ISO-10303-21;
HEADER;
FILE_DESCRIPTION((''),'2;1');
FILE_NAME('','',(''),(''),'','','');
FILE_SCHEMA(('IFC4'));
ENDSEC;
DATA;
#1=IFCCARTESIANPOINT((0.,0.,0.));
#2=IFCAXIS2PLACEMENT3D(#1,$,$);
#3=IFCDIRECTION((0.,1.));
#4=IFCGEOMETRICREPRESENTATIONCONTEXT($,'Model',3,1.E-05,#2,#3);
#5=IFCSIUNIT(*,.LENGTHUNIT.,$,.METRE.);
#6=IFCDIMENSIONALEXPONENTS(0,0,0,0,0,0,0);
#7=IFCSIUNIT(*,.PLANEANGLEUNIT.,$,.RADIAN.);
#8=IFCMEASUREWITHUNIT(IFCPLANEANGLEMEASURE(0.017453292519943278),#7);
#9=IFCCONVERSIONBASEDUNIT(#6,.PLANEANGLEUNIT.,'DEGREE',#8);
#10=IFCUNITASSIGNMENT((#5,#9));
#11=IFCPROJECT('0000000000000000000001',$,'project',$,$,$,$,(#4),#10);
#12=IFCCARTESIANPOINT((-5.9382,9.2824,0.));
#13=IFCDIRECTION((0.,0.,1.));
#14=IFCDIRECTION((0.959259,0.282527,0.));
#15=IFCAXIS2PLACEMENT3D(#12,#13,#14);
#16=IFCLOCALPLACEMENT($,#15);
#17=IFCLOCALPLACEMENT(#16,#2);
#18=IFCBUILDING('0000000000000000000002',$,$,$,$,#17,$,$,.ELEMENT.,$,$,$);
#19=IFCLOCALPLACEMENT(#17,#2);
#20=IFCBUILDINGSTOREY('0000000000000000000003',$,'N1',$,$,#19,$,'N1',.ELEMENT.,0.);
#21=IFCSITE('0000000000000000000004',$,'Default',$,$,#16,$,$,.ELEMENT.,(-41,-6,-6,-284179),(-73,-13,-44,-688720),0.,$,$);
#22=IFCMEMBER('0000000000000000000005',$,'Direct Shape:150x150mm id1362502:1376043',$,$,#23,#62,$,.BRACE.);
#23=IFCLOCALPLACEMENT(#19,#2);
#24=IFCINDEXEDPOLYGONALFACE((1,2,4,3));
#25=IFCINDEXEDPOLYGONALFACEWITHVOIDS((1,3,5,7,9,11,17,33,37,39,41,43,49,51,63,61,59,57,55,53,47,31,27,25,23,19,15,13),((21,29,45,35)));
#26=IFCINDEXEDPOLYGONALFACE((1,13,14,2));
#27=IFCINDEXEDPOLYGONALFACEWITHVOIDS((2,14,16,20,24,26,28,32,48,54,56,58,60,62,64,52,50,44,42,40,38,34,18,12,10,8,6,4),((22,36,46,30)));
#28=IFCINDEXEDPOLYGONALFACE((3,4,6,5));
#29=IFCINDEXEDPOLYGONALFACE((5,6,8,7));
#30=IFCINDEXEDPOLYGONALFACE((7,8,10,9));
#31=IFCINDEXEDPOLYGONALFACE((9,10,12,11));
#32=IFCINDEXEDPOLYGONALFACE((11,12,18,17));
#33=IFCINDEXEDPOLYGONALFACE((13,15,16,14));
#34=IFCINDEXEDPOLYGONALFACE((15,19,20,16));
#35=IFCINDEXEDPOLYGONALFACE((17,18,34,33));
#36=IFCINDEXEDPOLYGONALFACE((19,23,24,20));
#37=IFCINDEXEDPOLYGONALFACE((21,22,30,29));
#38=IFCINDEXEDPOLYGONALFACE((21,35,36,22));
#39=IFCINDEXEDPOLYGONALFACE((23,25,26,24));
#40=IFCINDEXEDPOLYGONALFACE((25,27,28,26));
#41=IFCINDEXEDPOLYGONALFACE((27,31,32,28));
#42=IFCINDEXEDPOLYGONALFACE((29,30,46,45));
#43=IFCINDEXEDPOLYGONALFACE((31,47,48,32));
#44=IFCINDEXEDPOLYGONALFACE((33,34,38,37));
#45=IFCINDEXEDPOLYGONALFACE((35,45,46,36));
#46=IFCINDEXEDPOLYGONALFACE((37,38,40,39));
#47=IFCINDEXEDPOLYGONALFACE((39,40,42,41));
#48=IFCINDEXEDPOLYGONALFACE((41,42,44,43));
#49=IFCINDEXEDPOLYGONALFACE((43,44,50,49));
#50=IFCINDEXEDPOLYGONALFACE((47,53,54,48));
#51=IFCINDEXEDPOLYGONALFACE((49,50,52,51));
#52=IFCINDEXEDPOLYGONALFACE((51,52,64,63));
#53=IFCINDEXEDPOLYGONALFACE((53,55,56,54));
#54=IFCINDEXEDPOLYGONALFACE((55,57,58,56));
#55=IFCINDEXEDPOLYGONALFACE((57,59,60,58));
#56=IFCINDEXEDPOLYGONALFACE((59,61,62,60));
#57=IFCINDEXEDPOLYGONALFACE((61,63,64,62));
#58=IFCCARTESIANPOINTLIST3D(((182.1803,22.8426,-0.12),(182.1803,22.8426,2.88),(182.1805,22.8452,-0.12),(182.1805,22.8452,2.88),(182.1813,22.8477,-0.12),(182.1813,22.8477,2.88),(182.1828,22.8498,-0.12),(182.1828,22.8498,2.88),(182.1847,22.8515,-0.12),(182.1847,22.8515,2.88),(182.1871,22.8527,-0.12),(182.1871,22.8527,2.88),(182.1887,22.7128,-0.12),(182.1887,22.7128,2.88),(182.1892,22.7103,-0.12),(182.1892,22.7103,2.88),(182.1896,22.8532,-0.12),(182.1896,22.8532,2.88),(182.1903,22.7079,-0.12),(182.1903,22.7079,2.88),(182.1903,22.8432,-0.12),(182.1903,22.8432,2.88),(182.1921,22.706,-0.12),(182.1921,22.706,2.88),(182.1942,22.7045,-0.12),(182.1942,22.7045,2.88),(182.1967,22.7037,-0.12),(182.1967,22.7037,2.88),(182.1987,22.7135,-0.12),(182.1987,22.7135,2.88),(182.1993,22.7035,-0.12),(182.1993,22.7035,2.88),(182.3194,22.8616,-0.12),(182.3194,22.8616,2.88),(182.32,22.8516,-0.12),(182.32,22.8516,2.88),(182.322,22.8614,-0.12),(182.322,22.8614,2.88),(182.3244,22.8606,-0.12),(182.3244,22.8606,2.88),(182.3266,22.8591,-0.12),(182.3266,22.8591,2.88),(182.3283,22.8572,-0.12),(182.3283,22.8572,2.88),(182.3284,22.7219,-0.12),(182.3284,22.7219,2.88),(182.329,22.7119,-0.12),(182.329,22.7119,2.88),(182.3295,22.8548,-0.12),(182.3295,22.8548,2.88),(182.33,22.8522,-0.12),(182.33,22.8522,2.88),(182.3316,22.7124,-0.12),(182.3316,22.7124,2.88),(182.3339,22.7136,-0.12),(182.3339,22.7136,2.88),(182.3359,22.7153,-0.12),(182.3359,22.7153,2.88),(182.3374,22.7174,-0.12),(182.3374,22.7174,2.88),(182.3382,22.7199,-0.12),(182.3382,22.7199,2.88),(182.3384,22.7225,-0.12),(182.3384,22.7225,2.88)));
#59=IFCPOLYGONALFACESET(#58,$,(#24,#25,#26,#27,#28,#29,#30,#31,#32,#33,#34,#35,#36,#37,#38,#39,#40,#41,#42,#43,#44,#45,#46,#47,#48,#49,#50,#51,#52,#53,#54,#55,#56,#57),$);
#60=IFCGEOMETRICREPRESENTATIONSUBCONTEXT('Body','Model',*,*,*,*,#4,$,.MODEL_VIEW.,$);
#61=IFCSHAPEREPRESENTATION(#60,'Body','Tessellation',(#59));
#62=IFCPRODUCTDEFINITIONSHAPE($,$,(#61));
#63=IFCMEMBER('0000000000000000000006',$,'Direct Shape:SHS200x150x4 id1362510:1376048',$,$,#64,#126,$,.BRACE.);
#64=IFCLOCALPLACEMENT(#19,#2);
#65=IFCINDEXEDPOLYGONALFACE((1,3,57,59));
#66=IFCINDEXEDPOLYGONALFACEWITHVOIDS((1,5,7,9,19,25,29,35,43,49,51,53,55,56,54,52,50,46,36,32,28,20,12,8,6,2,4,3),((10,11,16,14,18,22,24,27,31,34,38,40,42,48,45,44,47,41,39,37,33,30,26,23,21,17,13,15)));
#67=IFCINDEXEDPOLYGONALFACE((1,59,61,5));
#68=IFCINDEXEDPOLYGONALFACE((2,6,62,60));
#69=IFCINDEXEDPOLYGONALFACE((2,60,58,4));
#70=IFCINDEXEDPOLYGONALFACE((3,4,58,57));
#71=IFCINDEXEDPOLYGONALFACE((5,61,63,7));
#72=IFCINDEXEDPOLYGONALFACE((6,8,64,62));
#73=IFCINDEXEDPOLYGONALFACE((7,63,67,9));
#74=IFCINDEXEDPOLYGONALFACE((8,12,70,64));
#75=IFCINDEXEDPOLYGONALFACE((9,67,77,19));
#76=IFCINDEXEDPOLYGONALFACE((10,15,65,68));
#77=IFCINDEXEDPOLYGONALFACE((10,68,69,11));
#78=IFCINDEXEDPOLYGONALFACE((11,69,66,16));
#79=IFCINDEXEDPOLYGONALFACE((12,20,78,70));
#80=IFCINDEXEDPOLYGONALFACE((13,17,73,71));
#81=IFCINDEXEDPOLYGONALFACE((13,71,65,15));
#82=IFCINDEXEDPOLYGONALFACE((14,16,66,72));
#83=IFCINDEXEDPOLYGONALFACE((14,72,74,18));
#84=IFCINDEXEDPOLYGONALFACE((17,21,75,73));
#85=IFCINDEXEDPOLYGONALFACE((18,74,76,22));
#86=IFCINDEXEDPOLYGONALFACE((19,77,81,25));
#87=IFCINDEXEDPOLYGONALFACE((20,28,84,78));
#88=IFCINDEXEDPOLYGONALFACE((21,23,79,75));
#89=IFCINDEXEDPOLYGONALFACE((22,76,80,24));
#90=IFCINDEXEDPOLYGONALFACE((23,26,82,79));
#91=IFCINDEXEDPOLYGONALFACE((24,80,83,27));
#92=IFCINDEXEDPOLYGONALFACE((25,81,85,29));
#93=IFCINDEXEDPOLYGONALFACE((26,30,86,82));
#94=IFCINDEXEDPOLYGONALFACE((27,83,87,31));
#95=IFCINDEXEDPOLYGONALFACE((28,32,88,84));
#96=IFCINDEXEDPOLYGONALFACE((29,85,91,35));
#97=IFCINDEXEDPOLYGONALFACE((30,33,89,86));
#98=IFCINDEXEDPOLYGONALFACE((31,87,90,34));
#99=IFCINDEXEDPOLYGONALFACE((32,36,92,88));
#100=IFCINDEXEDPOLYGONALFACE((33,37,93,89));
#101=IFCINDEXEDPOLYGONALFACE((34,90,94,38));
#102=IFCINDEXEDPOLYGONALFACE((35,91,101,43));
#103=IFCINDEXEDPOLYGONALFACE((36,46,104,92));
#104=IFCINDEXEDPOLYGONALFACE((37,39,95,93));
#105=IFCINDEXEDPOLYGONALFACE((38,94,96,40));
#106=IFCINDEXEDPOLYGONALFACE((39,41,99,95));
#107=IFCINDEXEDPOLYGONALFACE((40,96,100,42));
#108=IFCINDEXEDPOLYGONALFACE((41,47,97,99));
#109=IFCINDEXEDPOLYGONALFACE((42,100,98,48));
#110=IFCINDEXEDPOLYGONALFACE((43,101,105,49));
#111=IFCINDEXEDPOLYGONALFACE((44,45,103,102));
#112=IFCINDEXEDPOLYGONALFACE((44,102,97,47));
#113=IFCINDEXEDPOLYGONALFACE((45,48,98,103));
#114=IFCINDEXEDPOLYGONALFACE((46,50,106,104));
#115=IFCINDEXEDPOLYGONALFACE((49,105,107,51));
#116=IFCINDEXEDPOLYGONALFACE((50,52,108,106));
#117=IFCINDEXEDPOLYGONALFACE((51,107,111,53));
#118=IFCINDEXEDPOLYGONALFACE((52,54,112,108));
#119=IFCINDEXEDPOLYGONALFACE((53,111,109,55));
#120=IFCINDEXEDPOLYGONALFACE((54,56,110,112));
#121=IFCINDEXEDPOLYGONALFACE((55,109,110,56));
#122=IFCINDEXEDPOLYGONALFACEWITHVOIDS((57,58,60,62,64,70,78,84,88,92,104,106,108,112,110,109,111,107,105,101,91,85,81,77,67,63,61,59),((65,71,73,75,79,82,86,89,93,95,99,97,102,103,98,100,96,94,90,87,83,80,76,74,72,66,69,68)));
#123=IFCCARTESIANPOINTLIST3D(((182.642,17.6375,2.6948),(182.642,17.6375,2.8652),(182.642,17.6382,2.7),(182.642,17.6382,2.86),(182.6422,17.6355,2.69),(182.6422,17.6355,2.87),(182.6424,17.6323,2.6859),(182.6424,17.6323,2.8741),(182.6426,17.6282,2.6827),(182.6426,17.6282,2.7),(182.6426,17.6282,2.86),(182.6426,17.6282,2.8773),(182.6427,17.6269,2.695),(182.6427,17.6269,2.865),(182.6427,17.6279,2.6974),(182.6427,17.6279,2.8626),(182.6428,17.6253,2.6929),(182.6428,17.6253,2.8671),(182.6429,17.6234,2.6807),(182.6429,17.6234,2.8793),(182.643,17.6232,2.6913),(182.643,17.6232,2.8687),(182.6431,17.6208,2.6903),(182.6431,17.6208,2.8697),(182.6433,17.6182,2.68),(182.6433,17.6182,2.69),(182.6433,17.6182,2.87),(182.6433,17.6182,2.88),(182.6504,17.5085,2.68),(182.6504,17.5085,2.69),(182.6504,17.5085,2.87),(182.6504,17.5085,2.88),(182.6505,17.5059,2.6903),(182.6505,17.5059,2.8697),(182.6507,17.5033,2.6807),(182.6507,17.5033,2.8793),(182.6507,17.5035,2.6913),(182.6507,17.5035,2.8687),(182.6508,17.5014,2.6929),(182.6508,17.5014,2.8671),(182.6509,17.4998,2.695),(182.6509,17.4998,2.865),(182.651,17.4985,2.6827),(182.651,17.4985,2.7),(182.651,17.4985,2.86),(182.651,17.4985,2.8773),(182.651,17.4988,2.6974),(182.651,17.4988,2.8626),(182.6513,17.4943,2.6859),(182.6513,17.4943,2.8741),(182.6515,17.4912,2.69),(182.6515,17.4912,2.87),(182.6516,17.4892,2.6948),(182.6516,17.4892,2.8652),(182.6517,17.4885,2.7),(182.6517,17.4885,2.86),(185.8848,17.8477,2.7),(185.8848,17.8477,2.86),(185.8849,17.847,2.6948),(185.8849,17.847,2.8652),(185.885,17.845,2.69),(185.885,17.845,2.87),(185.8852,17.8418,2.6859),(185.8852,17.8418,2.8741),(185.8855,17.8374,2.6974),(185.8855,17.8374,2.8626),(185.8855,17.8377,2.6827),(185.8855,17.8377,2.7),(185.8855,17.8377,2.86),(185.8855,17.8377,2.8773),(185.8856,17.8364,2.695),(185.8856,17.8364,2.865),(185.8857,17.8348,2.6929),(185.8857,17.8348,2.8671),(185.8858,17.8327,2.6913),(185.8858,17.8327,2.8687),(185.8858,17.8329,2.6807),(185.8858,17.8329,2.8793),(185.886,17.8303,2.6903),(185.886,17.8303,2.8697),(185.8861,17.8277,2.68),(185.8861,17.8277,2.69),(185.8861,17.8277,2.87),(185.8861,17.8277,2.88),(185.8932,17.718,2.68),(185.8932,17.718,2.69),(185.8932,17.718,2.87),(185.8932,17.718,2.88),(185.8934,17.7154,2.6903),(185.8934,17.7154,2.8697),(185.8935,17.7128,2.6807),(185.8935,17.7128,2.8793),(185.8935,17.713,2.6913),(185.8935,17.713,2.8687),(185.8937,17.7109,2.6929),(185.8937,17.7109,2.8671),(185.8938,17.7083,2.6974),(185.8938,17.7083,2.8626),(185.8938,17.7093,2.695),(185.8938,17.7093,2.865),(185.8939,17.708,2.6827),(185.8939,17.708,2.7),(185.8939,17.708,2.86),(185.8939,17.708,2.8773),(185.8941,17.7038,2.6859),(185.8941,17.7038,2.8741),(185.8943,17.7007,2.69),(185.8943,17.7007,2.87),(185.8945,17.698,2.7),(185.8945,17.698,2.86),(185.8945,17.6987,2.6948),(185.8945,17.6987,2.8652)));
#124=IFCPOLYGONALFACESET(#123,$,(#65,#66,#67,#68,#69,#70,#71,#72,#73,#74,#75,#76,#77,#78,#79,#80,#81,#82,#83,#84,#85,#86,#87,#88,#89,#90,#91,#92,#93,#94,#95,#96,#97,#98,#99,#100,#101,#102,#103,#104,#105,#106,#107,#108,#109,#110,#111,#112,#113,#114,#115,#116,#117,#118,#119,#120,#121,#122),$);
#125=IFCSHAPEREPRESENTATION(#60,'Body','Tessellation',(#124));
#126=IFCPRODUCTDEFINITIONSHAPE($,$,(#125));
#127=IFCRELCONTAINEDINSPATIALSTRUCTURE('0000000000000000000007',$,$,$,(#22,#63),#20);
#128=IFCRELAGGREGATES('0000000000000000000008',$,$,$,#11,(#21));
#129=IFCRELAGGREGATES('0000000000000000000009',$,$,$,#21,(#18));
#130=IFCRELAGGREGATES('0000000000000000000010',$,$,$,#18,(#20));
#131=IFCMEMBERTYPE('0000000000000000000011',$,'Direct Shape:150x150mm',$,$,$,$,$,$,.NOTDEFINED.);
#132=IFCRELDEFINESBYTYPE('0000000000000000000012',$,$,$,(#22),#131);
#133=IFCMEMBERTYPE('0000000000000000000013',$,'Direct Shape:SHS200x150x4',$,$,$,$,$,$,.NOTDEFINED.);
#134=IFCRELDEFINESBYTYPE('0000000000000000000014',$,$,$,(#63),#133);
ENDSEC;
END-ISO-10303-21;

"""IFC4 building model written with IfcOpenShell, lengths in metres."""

from ifc_helpers import new_model, entity, si_unit, converted_unit, direction, frame, frame_2d, origin, place, context, subcontext, project, spatial, polyline, circle_curve, parameter, trimmed, segment, composite_curve, outline, extrude, type_object, element, save


model = new_model("IFC4")

# Units and contexts
model_context = context("Model", 3, precision=1e-05, world=origin(), true_north=direction((0.0, 1.0)))
body_context = subcontext(model_context, "Body", "Model", "MODEL_VIEW")
ifc_project = project(units=[si_unit("LENGTHUNIT", "METRE"), converted_unit("PLANEANGLEUNIT", "DEGREE", entity("IfcPlaneAngleMeasure", 0.017453292519943278), si_unit("PLANEANGLEUNIT", "RADIAN"), dimensions=[0, 0, 0, 0, 0, 0, 0])], contexts=[model_context])

# Site, building, storey
site_placement = place(None, frame((-5.9382, 9.2824, 0.0), z_axis=(0.0, 0.0, 1.0), x_axis=(0.959259, 0.282527, 0.0)))
site = spatial("IfcSite", under=ifc_project, at=site_placement, Name="Default", CompositionType="ELEMENT", RefLatitude=(-41, -6, -6, -284179), RefLongitude=(-73, -13, -44, -688720), RefElevation=0.0)
building_placement = place(site_placement, origin())
building = spatial("IfcBuilding", under=site, at=building_placement, CompositionType="ELEMENT")
storey_placement = place(building_placement, origin())
storey = spatial("IfcBuildingStorey", under=building, at=storey_placement, Name="N1", LongName="N1", CompositionType="ELEMENT", Elevation=0.0)

# Members
member_type_1 = type_object("IfcMemberType", Name="Direct Shape:150x150mm", PredefinedType="NOTDEFINED")
member_1_placement = place(storey_placement, origin())
element("IfcMember", 1, at=member_1_placement, inside=storey, type_object=member_type_1, Name="Direct Shape:150x150mm id1362502:1376043", PredefinedType="BRACE", context=body_context, shape_type="SweptSolid", body=[
    extrude(outline(composite_curve([segment(polyline([(-0.065, -0.075), (0.065, -0.075)]), True, "CONTINUOUS"), segment(trimmed(circle_curve(frame_2d((0.065, -0.065), x_axis=(-1.0, 0.0)), 0.01), [parameter(90.0)], [parameter(180.0)], True, "PARAMETER"), True, "CONTINUOUS"), segment(polyline([(0.075, -0.065), (0.075, 0.065)]), True, "CONTINUOUS"), segment(trimmed(circle_curve(frame_2d((0.065, 0.065), x_axis=(-1.0, 0.0)), 0.01), [parameter(180.0)], [parameter(270.0)], True, "PARAMETER"), True, "CONTINUOUS"), segment(polyline([(0.065, 0.075), (-0.065, 0.075)]), True, "CONTINUOUS"), segment(trimmed(circle_curve(frame_2d((-0.065, 0.065), x_axis=(-1.0, 0.0)), 0.01), [parameter(270.0)], [parameter(360.0)], True, "PARAMETER"), True, "CONTINUOUS"), segment(polyline([(-0.075, 0.065), (-0.075, -0.065)]), True, "CONTINUOUS"), segment(trimmed(circle_curve(frame_2d((-0.065, -0.065), x_axis=(-1.0, 0.0)), 0.01), [parameter(360.0)], [parameter(90.0)], True, "PARAMETER"), True, "CONTINUOUS")], self_intersect=False), holes=[polyline([(-0.065, -0.065), (-0.065, 0.065), (0.065, 0.065), (0.065, -0.065), (-0.065, -0.065)])]), frame((182.2593, 22.7825, -0.12), z_axis=(0.0, 0.0, 1.0), x_axis=(-0.99792, -0.064471, 0.0)), (0.0, 0.0, 1.0), 3.0),
])
member_type_2 = type_object("IfcMemberType", Name="Direct Shape:SHS200x150x4", PredefinedType="NOTDEFINED")
member_2_placement = place(storey_placement, origin())
element("IfcMember", 2, at=member_2_placement, inside=storey, type_object=member_type_2, Name="Direct Shape:SHS200x150x4 id1362510:1376048", PredefinedType="BRACE", context=body_context, shape_type="SweptSolid", body=[
    extrude(outline(composite_curve([segment(polyline([(-0.08, -0.075), (0.08, -0.075)]), True, "CONTINUOUS"), segment(trimmed(circle_curve(frame_2d((0.08, -0.055), x_axis=(0.0, 1.0)), 0.02), [parameter(180.0)], [parameter(270.0)], True, "PARAMETER"), True, "CONTINUOUS"), segment(polyline([(0.1, -0.055), (0.1, 0.055)]), True, "CONTINUOUS"), segment(trimmed(circle_curve(frame_2d((0.08, 0.055), x_axis=(0.0, 1.0)), 0.02), [parameter(270.0)], [parameter(0.0)], True, "PARAMETER"), True, "CONTINUOUS"), segment(polyline([(0.08, 0.075), (-0.08, 0.075)]), True, "CONTINUOUS"), segment(trimmed(circle_curve(frame_2d((-0.08, 0.055), x_axis=(0.0, 1.0)), 0.02), [parameter(360.0)], [parameter(90.0)], True, "PARAMETER"), True, "CONTINUOUS"), segment(polyline([(-0.1, 0.055), (-0.1, -0.055)]), True, "CONTINUOUS"), segment(trimmed(circle_curve(frame_2d((-0.08, -0.055), x_axis=(0.0, 1.0)), 0.02), [parameter(90.0)], [parameter(180.0)], True, "PARAMETER"), True, "CONTINUOUS")], self_intersect=False), holes=[composite_curve([segment(trimmed(circle_curve(frame_2d((-0.08, 0.055), x_axis=(0.0, 1.0)), 0.01), [parameter(360.0)], [parameter(90.0)], True, "PARAMETER"), False, "CONTINUOUS"), segment(polyline([(-0.08, 0.065), (0.08, 0.065)]), True, "CONTINUOUS"), segment(trimmed(circle_curve(frame_2d((0.08, 0.055), x_axis=(0.0, 1.0)), 0.01), [parameter(270.0)], [parameter(0.0)], True, "PARAMETER"), False, "CONTINUOUS"), segment(polyline([(0.09, 0.055), (0.09, -0.055)]), True, "CONTINUOUS"), segment(trimmed(circle_curve(frame_2d((0.08, -0.055), x_axis=(0.0, 1.0)), 0.01), [parameter(180.0)], [parameter(270.0)], True, "PARAMETER"), False, "CONTINUOUS"), segment(polyline([(0.08, -0.065), (-0.08, -0.065)]), True, "CONTINUOUS"), segment(trimmed(circle_curve(frame_2d((-0.08, -0.055), x_axis=(0.0, 1.0)), 0.01), [parameter(90.0)], [parameter(180.0)], True, "PARAMETER"), False, "CONTINUOUS"), segment(polyline([(-0.09, -0.055), (-0.09, 0.055)]), True, "CONTINUOUS")], self_intersect=False)]), frame((182.6468, 17.5633, 2.78), z_axis=(0.99792, 0.064471, 0.0), x_axis=(0.0, 0.0, -1.0)), (0.0, 0.0, 1.0), 3.2496),
])

save(model, "model.ifc")
